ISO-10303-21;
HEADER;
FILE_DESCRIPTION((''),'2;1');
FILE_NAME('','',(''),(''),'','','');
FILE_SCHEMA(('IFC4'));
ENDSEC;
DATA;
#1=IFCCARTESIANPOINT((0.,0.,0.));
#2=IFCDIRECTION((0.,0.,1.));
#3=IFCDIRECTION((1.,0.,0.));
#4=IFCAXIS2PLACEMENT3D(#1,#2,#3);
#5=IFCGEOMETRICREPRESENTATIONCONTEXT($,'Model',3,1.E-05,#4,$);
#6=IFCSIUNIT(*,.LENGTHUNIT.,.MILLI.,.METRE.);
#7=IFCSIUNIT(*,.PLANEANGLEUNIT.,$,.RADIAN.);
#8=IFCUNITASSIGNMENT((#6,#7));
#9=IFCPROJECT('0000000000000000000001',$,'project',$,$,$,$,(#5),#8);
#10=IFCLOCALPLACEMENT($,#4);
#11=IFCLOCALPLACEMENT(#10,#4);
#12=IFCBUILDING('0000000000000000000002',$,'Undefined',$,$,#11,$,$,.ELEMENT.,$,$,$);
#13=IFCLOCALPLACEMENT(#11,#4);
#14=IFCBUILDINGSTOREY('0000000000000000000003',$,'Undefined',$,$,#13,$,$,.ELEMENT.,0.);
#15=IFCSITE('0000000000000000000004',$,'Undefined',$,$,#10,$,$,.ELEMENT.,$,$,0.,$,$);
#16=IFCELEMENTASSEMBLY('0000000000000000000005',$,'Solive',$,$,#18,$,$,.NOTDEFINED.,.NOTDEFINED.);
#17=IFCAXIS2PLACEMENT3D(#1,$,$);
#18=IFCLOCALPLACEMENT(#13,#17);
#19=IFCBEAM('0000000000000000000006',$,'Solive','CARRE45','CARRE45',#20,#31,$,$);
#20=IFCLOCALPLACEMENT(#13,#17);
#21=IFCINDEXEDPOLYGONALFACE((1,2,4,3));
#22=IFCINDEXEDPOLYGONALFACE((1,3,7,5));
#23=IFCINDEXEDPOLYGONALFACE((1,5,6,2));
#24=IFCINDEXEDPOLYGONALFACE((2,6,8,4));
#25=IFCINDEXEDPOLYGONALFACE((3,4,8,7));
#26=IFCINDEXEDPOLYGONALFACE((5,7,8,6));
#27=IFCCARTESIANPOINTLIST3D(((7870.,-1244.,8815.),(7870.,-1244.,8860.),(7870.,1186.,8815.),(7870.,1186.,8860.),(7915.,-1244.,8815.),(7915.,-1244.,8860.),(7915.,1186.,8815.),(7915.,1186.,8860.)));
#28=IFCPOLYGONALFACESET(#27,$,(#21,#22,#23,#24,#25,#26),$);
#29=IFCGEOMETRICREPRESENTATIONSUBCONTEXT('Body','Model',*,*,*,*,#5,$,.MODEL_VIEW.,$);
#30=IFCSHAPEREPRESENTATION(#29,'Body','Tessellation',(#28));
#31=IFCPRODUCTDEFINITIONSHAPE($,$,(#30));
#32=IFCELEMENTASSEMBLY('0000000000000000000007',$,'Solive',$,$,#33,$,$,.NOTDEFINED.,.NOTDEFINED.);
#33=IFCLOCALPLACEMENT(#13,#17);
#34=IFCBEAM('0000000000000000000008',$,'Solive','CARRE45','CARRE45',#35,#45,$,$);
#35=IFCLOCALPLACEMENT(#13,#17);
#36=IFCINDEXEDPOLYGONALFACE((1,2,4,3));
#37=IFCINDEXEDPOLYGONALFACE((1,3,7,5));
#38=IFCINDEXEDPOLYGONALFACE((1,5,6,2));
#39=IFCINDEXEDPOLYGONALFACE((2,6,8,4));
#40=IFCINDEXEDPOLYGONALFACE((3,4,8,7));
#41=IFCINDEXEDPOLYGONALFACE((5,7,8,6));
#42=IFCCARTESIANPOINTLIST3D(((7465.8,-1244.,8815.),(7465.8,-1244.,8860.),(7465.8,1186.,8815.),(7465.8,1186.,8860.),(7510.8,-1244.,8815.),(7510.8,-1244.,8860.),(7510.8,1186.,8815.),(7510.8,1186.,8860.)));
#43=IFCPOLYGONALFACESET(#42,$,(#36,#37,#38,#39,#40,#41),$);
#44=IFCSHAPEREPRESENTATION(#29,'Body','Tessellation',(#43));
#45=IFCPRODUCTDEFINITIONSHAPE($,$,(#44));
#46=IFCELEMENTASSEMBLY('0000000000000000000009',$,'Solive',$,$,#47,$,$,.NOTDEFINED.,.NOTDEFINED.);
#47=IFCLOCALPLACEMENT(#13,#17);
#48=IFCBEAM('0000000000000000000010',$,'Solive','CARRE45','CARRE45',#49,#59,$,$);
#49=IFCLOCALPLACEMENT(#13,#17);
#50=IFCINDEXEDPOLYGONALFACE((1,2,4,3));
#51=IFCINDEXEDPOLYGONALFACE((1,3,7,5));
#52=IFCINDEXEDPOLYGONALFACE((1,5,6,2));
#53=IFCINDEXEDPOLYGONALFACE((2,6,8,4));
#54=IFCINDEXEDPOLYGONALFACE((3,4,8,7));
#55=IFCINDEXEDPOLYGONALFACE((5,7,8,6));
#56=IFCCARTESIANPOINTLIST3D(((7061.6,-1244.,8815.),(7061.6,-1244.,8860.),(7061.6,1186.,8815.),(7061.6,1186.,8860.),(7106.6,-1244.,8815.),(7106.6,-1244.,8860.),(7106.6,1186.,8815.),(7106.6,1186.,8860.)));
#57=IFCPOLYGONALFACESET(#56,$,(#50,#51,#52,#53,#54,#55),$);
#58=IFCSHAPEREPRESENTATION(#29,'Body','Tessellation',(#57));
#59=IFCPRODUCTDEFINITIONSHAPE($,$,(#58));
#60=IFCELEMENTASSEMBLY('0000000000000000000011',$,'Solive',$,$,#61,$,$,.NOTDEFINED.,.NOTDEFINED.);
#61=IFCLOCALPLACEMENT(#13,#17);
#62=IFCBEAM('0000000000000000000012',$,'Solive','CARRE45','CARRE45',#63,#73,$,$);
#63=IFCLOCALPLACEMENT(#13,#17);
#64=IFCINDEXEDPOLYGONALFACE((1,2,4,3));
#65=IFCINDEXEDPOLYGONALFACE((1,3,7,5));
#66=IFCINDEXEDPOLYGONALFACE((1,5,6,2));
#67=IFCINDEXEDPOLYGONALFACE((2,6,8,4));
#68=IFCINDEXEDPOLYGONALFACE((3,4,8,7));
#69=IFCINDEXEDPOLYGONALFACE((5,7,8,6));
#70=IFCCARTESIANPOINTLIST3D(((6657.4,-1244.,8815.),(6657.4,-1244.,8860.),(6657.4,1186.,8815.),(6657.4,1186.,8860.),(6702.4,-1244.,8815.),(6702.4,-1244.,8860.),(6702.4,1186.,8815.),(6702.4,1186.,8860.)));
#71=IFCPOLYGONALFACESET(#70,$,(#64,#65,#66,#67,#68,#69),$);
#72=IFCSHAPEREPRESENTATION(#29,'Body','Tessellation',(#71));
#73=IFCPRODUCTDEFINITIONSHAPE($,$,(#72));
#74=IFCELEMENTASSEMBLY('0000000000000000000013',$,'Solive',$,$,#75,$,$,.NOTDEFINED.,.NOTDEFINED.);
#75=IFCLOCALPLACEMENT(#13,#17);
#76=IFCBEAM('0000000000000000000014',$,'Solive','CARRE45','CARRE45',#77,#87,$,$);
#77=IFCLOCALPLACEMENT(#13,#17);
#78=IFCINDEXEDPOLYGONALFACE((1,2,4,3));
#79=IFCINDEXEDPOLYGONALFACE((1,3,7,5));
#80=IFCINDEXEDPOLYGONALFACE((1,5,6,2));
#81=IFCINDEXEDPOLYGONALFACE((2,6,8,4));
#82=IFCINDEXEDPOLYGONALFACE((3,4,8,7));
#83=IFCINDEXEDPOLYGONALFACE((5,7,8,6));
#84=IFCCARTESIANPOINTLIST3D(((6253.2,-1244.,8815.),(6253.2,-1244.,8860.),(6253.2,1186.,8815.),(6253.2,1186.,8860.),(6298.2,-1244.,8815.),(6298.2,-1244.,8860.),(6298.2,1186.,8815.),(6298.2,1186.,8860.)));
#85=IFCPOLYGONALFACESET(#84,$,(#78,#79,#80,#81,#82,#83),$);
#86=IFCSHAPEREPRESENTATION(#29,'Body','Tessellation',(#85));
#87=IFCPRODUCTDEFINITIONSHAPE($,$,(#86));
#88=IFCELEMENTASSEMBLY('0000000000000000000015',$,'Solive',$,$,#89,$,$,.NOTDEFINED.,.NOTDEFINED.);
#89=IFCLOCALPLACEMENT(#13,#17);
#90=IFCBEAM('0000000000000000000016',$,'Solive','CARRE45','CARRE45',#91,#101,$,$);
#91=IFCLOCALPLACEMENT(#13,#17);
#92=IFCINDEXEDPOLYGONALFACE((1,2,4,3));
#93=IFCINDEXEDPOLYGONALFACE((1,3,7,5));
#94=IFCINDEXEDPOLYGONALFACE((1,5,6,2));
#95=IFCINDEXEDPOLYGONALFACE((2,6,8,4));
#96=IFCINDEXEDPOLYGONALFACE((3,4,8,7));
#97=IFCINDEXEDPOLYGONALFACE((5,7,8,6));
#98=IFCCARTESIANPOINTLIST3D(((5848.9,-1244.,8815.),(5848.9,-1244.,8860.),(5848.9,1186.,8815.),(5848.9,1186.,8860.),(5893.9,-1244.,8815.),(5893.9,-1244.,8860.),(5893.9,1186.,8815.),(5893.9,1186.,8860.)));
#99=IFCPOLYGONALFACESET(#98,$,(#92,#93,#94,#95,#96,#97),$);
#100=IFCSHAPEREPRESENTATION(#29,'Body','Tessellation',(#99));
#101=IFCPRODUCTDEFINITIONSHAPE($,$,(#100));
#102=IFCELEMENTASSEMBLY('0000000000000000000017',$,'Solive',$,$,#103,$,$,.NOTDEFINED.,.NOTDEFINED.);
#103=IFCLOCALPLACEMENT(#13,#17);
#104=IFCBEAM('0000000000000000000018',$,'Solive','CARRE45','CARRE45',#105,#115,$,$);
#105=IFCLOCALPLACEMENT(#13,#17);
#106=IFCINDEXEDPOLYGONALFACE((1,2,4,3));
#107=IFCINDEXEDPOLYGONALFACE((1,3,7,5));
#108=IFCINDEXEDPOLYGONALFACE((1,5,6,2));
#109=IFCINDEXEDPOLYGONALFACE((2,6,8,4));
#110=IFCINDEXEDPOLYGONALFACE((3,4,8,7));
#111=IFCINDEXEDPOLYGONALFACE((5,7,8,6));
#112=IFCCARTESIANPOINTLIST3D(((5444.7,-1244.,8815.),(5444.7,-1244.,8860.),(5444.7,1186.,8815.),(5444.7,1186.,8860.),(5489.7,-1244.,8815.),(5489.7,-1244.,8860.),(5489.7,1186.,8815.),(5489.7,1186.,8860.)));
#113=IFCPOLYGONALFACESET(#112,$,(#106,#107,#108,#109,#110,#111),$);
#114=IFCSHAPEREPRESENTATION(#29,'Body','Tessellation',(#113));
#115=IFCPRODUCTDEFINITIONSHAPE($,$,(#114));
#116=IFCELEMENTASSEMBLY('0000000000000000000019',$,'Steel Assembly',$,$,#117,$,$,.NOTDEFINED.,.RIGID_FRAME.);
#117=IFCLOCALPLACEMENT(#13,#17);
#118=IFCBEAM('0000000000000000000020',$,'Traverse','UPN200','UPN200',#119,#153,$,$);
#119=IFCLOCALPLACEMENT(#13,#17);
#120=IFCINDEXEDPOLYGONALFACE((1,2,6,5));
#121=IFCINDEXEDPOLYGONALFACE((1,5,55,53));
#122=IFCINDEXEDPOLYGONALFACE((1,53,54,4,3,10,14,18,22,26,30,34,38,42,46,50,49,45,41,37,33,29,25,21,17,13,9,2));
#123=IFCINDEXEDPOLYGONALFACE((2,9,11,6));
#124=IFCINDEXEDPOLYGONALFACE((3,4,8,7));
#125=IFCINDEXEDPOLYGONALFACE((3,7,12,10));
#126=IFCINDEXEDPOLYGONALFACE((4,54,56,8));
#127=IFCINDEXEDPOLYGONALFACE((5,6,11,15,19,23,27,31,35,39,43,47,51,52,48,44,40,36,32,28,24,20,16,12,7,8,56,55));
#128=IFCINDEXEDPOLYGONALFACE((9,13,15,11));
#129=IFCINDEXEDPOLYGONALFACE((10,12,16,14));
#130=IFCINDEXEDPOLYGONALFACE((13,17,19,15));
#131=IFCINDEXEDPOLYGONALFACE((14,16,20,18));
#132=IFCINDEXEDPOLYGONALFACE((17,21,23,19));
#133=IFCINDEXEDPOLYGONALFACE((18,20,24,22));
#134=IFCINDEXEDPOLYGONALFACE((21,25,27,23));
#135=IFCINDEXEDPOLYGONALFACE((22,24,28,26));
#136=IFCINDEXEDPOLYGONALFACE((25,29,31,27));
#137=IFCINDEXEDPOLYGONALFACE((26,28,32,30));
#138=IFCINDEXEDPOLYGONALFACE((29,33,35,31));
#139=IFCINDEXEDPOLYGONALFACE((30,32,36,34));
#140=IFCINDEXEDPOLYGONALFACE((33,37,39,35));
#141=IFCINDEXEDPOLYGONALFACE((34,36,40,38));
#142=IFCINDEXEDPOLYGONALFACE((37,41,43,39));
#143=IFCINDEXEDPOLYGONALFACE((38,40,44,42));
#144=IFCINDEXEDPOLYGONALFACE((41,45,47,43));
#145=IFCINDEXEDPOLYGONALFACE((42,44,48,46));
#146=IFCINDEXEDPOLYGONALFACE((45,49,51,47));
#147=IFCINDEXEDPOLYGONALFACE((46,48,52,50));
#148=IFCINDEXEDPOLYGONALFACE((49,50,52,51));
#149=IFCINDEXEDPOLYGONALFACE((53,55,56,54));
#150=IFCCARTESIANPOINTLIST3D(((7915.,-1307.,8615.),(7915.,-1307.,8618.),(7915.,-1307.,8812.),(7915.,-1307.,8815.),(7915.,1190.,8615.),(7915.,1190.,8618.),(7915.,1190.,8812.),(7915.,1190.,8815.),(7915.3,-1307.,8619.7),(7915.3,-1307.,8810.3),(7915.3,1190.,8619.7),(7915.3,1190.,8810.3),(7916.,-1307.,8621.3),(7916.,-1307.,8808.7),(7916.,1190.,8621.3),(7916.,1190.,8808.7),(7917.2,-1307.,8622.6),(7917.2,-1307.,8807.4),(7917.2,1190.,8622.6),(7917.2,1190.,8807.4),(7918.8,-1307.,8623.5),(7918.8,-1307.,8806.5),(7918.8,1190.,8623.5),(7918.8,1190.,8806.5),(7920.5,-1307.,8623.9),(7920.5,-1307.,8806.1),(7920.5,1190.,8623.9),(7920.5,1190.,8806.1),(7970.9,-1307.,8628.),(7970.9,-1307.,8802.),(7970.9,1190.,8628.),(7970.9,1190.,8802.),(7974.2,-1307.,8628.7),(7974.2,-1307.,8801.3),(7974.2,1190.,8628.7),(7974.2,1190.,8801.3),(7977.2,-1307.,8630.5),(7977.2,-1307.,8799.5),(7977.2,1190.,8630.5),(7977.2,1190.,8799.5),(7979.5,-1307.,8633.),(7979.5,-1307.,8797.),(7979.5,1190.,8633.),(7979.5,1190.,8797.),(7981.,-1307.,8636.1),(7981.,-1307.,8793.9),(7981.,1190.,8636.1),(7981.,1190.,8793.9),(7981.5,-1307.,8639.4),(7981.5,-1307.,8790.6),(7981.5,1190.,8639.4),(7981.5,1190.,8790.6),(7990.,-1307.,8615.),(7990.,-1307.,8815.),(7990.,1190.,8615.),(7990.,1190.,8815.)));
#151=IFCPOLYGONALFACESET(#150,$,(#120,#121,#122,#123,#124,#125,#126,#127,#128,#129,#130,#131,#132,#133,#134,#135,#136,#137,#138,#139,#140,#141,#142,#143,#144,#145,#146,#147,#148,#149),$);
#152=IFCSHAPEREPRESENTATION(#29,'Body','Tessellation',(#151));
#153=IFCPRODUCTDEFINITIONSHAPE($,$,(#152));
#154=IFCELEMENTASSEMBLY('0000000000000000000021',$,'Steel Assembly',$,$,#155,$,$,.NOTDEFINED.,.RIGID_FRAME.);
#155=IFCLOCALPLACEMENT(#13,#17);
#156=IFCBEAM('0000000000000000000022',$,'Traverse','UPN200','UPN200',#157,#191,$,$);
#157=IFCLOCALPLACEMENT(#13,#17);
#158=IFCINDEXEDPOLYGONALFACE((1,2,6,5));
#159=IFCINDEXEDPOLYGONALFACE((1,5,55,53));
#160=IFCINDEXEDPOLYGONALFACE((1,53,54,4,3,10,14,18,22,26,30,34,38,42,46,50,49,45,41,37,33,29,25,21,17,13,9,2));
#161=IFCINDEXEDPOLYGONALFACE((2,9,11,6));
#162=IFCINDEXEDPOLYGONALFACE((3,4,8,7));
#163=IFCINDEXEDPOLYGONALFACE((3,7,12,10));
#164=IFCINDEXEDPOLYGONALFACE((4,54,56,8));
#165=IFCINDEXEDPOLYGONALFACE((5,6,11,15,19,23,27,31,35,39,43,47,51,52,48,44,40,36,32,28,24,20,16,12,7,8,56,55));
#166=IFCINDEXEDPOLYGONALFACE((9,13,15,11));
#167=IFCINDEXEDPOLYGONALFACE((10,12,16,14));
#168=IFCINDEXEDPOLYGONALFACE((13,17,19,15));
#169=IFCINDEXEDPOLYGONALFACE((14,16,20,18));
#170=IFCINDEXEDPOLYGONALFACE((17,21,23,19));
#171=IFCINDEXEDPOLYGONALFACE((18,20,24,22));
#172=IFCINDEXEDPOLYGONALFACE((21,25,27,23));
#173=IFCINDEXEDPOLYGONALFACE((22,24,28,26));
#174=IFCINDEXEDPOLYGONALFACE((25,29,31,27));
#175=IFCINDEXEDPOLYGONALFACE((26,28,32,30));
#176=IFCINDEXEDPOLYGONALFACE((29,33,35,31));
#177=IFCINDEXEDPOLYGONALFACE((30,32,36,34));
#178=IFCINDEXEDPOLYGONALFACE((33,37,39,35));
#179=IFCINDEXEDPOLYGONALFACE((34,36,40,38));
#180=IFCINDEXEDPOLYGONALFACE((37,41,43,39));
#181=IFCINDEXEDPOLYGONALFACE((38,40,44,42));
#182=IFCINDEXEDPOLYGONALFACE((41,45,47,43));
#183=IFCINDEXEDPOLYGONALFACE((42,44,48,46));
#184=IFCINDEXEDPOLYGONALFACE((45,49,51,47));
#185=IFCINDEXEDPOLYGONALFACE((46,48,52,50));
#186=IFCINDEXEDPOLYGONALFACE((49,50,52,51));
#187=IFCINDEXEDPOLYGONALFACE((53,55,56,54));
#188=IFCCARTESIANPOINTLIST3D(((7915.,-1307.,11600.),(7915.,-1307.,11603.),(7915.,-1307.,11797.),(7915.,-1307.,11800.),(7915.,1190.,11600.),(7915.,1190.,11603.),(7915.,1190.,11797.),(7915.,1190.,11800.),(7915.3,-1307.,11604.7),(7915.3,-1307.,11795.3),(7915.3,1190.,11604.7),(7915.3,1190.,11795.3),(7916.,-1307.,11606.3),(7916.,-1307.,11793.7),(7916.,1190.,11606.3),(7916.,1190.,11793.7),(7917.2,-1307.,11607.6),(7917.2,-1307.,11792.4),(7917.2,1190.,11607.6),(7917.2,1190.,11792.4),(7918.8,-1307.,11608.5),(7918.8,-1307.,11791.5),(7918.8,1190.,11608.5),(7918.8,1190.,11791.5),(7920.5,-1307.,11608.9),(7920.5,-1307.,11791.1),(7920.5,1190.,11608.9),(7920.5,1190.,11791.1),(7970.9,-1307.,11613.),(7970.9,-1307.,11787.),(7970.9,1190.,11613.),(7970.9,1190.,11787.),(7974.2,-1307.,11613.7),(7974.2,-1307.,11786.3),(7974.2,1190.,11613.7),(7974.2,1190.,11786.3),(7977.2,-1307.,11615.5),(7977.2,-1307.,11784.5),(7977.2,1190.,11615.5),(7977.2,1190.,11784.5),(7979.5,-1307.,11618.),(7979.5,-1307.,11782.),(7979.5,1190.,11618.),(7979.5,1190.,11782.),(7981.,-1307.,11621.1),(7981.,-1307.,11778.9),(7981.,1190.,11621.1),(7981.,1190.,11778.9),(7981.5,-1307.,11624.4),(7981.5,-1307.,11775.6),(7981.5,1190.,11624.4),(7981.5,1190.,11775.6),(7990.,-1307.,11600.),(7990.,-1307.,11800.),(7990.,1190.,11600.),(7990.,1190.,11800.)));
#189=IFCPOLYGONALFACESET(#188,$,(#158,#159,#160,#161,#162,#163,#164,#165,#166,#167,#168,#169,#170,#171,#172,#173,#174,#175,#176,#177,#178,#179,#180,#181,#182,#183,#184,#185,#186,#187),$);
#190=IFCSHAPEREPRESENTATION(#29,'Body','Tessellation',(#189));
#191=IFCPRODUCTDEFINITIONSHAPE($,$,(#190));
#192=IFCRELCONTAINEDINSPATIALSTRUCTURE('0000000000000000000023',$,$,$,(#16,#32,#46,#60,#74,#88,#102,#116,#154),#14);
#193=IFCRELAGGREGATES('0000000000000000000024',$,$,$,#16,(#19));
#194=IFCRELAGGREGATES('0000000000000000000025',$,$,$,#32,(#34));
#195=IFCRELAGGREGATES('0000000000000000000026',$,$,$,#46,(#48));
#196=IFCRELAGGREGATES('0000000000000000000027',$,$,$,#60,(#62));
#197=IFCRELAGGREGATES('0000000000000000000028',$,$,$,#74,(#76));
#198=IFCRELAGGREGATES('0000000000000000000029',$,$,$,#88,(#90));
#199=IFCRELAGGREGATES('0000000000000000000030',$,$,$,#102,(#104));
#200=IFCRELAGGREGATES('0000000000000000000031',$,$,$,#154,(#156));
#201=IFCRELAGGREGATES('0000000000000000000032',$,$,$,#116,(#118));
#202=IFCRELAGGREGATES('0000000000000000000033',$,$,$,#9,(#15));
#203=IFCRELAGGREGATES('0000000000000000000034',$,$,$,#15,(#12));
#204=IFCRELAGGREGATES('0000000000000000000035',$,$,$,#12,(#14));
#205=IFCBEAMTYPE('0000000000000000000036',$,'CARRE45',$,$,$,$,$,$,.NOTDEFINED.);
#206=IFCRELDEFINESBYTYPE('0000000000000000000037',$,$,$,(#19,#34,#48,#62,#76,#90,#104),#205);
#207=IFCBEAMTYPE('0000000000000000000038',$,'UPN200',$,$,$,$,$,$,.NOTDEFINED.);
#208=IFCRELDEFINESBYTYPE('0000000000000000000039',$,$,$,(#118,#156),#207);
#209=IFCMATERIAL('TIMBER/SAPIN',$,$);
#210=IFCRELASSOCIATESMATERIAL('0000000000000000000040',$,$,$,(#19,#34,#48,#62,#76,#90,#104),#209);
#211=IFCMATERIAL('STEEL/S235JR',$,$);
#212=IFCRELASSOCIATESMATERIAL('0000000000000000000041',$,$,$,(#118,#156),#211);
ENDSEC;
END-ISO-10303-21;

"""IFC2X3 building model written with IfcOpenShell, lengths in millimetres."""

from ifc_helpers import new_model, si_unit, frame, origin_with_axes, origin_2d_with_axis, place, context, subcontext, project, spatial, rectangle, u_section, extrude, material, type_object, element, aggregate, save


model = new_model("IFC2X3")

# Units and contexts
model_context = context("Model", 3, precision=1e-05, world=origin_with_axes())
body_context = subcontext(model_context, "Body", "Model", "MODEL_VIEW")
ifc_project = project(units=[si_unit("LENGTHUNIT", "METRE", prefix="MILLI"), si_unit("PLANEANGLEUNIT", "RADIAN")], contexts=[model_context])

# Site, building, storey
site_placement = place(None, origin_with_axes())
site = spatial("IfcSite", under=ifc_project, at=site_placement, Name="Undefined", CompositionType="ELEMENT", RefElevation=0.0)
building_placement = place(site_placement, origin_with_axes())
building = spatial("IfcBuilding", under=site, at=building_placement, Name="Undefined", CompositionType="ELEMENT")
storey_placement = place(building_placement, origin_with_axes())
storey = spatial("IfcBuildingStorey", under=building, at=storey_placement, Name="Undefined", CompositionType="ELEMENT", Elevation=0.0)

# Element assemblies, beams
ifc_material_1 = material(Name="STEEL/S235JR")
assembly_1_placement = place(storey_placement, origin_with_axes())
assembly_1 = element("IfcElementAssembly", 1, at=assembly_1_placement, inside=storey, Name="Solive", AssemblyPlace="NOTDEFINED", PredefinedType="NOTDEFINED")
ifc_material_2 = material(Name="TIMBER/SAPIN")
beam_type_1 = type_object("IfcBeamType", Name="CARRE45", PredefinedType="NOTDEFINED")
beam_1_placement = place(assembly_1_placement, frame((7892.5, 1186.0, 8837.5), z_axis=(0.0, 0.0, -1.0), x_axis=(0.0, -1.0, 0.0)))
beam_1 = element("IfcBeam", 2, at=beam_1_placement, type_object=beam_type_1, material=ifc_material_2, Name="Solive", Description="CARRE45", ObjectType="CARRE45", context=body_context, shape_type="SweptSolid", body=[
    extrude(rectangle(XDim=45.0, YDim=45.0, at=origin_2d_with_axis()), frame((2430.0, 0.0, 0.0), z_axis=(-1.0, 0.0, 0.0), x_axis=(0.0, -1.0, 0.0)), (0.0, 0.0, 1.0), 2430.0),
])
aggregate(assembly_1, [beam_1])
assembly_2_placement = place(storey_placement, origin_with_axes())
assembly_2 = element("IfcElementAssembly", 3, at=assembly_2_placement, inside=storey, Name="Solive", AssemblyPlace="NOTDEFINED", PredefinedType="NOTDEFINED")
beam_2_placement = place(assembly_2_placement, frame((7488.3, 1186.0, 8837.5), z_axis=(0.0, 0.0, -1.0), x_axis=(0.0, -1.0, 0.0)))
beam_2 = element("IfcBeam", 4, at=beam_2_placement, type_object=beam_type_1, material=ifc_material_2, Name="Solive", Description="CARRE45", ObjectType="CARRE45", context=body_context, shape_type="SweptSolid", body=[
    extrude(rectangle(XDim=45.0, YDim=45.0, at=origin_2d_with_axis()), frame((2430.0, 0.0, 0.0), z_axis=(-1.0, 0.0, 0.0), x_axis=(0.0, -1.0, 0.0)), (0.0, 0.0, 1.0), 2430.0),
])
aggregate(assembly_2, [beam_2])
assembly_3_placement = place(storey_placement, origin_with_axes())
assembly_3 = element("IfcElementAssembly", 5, at=assembly_3_placement, inside=storey, Name="Solive", AssemblyPlace="NOTDEFINED", PredefinedType="NOTDEFINED")
beam_3_placement = place(assembly_3_placement, frame((7084.1, 1186.0, 8837.5), z_axis=(0.0, 0.0, -1.0), x_axis=(0.0, -1.0, 0.0)))
beam_3 = element("IfcBeam", 6, at=beam_3_placement, type_object=beam_type_1, material=ifc_material_2, Name="Solive", Description="CARRE45", ObjectType="CARRE45", context=body_context, shape_type="SweptSolid", body=[
    extrude(rectangle(XDim=45.0, YDim=45.0, at=origin_2d_with_axis()), frame((2430.0, 0.0, 0.0), z_axis=(-1.0, 0.0, 0.0), x_axis=(0.0, -1.0, 0.0)), (0.0, 0.0, 1.0), 2430.0),
])
aggregate(assembly_3, [beam_3])
assembly_4_placement = place(storey_placement, origin_with_axes())
assembly_4 = element("IfcElementAssembly", 7, at=assembly_4_placement, inside=storey, Name="Solive", AssemblyPlace="NOTDEFINED", PredefinedType="NOTDEFINED")
beam_4_placement = place(assembly_4_placement, frame((6679.9, 1186.0, 8837.5), z_axis=(0.0, 0.0, -1.0), x_axis=(0.0, -1.0, 0.0)))
beam_4 = element("IfcBeam", 8, at=beam_4_placement, type_object=beam_type_1, material=ifc_material_2, Name="Solive", Description="CARRE45", ObjectType="CARRE45", context=body_context, shape_type="SweptSolid", body=[
    extrude(rectangle(XDim=45.0, YDim=45.0, at=origin_2d_with_axis()), frame((2430.0, 0.0, 0.0), z_axis=(-1.0, 0.0, 0.0), x_axis=(0.0, -1.0, 0.0)), (0.0, 0.0, 1.0), 2430.0),
])
aggregate(assembly_4, [beam_4])
assembly_5_placement = place(storey_placement, origin_with_axes())
assembly_5 = element("IfcElementAssembly", 9, at=assembly_5_placement, inside=storey, Name="Solive", AssemblyPlace="NOTDEFINED", PredefinedType="NOTDEFINED")
beam_5_placement = place(assembly_5_placement, frame((6275.7, 1186.0, 8837.5), z_axis=(0.0, 0.0, -1.0), x_axis=(0.0, -1.0, 0.0)))
beam_5 = element("IfcBeam", 10, at=beam_5_placement, type_object=beam_type_1, material=ifc_material_2, Name="Solive", Description="CARRE45", ObjectType="CARRE45", context=body_context, shape_type="SweptSolid", body=[
    extrude(rectangle(XDim=45.0, YDim=45.0, at=origin_2d_with_axis()), frame((2430.0, 0.0, 0.0), z_axis=(-1.0, 0.0, 0.0), x_axis=(0.0, -1.0, 0.0)), (0.0, 0.0, 1.0), 2430.0),
])
aggregate(assembly_5, [beam_5])
assembly_6_placement = place(storey_placement, origin_with_axes())
assembly_6 = element("IfcElementAssembly", 11, at=assembly_6_placement, inside=storey, Name="Solive", AssemblyPlace="NOTDEFINED", PredefinedType="NOTDEFINED")
beam_6_placement = place(assembly_6_placement, frame((5871.4, 1186.0, 8837.5), z_axis=(0.0, 0.0, -1.0), x_axis=(0.0, -1.0, 0.0)))
beam_6 = element("IfcBeam", 12, at=beam_6_placement, type_object=beam_type_1, material=ifc_material_2, Name="Solive", Description="CARRE45", ObjectType="CARRE45", context=body_context, shape_type="SweptSolid", body=[
    extrude(rectangle(XDim=45.0, YDim=45.0, at=origin_2d_with_axis()), frame((2430.0, 0.0, 0.0), z_axis=(-1.0, 0.0, 0.0), x_axis=(0.0, -1.0, 0.0)), (0.0, 0.0, 1.0), 2430.0),
])
aggregate(assembly_6, [beam_6])
assembly_7_placement = place(storey_placement, origin_with_axes())
assembly_7 = element("IfcElementAssembly", 13, at=assembly_7_placement, inside=storey, Name="Solive", AssemblyPlace="NOTDEFINED", PredefinedType="NOTDEFINED")
beam_7_placement = place(assembly_7_placement, frame((5467.2, 1186.0, 8837.5), z_axis=(0.0, 0.0, -1.0), x_axis=(0.0, -1.0, 0.0)))
beam_7 = element("IfcBeam", 14, at=beam_7_placement, type_object=beam_type_1, material=ifc_material_2, Name="Solive", Description="CARRE45", ObjectType="CARRE45", context=body_context, shape_type="SweptSolid", body=[
    extrude(rectangle(XDim=45.0, YDim=45.0, at=origin_2d_with_axis()), frame((2430.0, 0.0, 0.0), z_axis=(-1.0, 0.0, 0.0), x_axis=(0.0, -1.0, 0.0)), (0.0, 0.0, 1.0), 2430.0),
])
aggregate(assembly_7, [beam_7])
assembly_8_placement = place(storey_placement, origin_with_axes())
assembly_8 = element("IfcElementAssembly", 15, at=assembly_8_placement, inside=storey, Name="Steel Assembly", AssemblyPlace="NOTDEFINED", PredefinedType="RIGID_FRAME")
beam_type_2 = type_object("IfcBeamType", Name="UPN200", PredefinedType="NOTDEFINED")
beam_8_placement = place(assembly_8_placement, frame((7952.5, -1307.0, 8715.0), z_axis=(0.0, 0.0, -1.0), x_axis=(0.0, 1.0, 0.0)))
beam_8 = element("IfcBeam", 16, at=beam_8_placement, type_object=beam_type_2, material=ifc_material_1, Name="Traverse", Description="UPN200", ObjectType="UPN200", context=body_context, shape_type="SweptSolid", body=[
    extrude(u_section(Depth=200.0, FlangeWidth=75.0, WebThickness=8.5, FlangeThickness=11.5, FilletRadius=11.5, EdgeRadius=6.0, FlangeSlope=0.07983, at=origin_2d_with_axis()), frame((2497.0, 0.0, 0.0), z_axis=(-1.0, 0.0, 0.0), x_axis=(0.0, -1.0, 0.0)), (0.0, 0.0, 1.0), 2497.0),
])
assembly_9_placement = place(storey_placement, origin_with_axes())
assembly_9 = element("IfcElementAssembly", 17, at=assembly_9_placement, inside=storey, Name="Steel Assembly", AssemblyPlace="NOTDEFINED", PredefinedType="RIGID_FRAME")
beam_9_placement = place(assembly_9_placement, frame((7952.5, -1307.0, 11700.0), z_axis=(0.0, 0.0, -1.0), x_axis=(0.0, 1.0, 0.0)))
beam_9 = element("IfcBeam", 18, at=beam_9_placement, type_object=beam_type_2, material=ifc_material_1, Name="Traverse", Description="UPN200", ObjectType="UPN200", context=body_context, shape_type="SweptSolid", body=[
    extrude(u_section(Depth=200.0, FlangeWidth=75.0, WebThickness=8.5, FlangeThickness=11.5, FilletRadius=11.5, EdgeRadius=6.0, FlangeSlope=0.07983, at=origin_2d_with_axis()), frame((2497.0, 0.0, 0.0), z_axis=(-1.0, 0.0, 0.0), x_axis=(0.0, -1.0, 0.0)), (0.0, 0.0, 1.0), 2497.0),
])
aggregate(assembly_9, [beam_9])

aggregate(assembly_8, [beam_8])

save(model, "model.ifc")
